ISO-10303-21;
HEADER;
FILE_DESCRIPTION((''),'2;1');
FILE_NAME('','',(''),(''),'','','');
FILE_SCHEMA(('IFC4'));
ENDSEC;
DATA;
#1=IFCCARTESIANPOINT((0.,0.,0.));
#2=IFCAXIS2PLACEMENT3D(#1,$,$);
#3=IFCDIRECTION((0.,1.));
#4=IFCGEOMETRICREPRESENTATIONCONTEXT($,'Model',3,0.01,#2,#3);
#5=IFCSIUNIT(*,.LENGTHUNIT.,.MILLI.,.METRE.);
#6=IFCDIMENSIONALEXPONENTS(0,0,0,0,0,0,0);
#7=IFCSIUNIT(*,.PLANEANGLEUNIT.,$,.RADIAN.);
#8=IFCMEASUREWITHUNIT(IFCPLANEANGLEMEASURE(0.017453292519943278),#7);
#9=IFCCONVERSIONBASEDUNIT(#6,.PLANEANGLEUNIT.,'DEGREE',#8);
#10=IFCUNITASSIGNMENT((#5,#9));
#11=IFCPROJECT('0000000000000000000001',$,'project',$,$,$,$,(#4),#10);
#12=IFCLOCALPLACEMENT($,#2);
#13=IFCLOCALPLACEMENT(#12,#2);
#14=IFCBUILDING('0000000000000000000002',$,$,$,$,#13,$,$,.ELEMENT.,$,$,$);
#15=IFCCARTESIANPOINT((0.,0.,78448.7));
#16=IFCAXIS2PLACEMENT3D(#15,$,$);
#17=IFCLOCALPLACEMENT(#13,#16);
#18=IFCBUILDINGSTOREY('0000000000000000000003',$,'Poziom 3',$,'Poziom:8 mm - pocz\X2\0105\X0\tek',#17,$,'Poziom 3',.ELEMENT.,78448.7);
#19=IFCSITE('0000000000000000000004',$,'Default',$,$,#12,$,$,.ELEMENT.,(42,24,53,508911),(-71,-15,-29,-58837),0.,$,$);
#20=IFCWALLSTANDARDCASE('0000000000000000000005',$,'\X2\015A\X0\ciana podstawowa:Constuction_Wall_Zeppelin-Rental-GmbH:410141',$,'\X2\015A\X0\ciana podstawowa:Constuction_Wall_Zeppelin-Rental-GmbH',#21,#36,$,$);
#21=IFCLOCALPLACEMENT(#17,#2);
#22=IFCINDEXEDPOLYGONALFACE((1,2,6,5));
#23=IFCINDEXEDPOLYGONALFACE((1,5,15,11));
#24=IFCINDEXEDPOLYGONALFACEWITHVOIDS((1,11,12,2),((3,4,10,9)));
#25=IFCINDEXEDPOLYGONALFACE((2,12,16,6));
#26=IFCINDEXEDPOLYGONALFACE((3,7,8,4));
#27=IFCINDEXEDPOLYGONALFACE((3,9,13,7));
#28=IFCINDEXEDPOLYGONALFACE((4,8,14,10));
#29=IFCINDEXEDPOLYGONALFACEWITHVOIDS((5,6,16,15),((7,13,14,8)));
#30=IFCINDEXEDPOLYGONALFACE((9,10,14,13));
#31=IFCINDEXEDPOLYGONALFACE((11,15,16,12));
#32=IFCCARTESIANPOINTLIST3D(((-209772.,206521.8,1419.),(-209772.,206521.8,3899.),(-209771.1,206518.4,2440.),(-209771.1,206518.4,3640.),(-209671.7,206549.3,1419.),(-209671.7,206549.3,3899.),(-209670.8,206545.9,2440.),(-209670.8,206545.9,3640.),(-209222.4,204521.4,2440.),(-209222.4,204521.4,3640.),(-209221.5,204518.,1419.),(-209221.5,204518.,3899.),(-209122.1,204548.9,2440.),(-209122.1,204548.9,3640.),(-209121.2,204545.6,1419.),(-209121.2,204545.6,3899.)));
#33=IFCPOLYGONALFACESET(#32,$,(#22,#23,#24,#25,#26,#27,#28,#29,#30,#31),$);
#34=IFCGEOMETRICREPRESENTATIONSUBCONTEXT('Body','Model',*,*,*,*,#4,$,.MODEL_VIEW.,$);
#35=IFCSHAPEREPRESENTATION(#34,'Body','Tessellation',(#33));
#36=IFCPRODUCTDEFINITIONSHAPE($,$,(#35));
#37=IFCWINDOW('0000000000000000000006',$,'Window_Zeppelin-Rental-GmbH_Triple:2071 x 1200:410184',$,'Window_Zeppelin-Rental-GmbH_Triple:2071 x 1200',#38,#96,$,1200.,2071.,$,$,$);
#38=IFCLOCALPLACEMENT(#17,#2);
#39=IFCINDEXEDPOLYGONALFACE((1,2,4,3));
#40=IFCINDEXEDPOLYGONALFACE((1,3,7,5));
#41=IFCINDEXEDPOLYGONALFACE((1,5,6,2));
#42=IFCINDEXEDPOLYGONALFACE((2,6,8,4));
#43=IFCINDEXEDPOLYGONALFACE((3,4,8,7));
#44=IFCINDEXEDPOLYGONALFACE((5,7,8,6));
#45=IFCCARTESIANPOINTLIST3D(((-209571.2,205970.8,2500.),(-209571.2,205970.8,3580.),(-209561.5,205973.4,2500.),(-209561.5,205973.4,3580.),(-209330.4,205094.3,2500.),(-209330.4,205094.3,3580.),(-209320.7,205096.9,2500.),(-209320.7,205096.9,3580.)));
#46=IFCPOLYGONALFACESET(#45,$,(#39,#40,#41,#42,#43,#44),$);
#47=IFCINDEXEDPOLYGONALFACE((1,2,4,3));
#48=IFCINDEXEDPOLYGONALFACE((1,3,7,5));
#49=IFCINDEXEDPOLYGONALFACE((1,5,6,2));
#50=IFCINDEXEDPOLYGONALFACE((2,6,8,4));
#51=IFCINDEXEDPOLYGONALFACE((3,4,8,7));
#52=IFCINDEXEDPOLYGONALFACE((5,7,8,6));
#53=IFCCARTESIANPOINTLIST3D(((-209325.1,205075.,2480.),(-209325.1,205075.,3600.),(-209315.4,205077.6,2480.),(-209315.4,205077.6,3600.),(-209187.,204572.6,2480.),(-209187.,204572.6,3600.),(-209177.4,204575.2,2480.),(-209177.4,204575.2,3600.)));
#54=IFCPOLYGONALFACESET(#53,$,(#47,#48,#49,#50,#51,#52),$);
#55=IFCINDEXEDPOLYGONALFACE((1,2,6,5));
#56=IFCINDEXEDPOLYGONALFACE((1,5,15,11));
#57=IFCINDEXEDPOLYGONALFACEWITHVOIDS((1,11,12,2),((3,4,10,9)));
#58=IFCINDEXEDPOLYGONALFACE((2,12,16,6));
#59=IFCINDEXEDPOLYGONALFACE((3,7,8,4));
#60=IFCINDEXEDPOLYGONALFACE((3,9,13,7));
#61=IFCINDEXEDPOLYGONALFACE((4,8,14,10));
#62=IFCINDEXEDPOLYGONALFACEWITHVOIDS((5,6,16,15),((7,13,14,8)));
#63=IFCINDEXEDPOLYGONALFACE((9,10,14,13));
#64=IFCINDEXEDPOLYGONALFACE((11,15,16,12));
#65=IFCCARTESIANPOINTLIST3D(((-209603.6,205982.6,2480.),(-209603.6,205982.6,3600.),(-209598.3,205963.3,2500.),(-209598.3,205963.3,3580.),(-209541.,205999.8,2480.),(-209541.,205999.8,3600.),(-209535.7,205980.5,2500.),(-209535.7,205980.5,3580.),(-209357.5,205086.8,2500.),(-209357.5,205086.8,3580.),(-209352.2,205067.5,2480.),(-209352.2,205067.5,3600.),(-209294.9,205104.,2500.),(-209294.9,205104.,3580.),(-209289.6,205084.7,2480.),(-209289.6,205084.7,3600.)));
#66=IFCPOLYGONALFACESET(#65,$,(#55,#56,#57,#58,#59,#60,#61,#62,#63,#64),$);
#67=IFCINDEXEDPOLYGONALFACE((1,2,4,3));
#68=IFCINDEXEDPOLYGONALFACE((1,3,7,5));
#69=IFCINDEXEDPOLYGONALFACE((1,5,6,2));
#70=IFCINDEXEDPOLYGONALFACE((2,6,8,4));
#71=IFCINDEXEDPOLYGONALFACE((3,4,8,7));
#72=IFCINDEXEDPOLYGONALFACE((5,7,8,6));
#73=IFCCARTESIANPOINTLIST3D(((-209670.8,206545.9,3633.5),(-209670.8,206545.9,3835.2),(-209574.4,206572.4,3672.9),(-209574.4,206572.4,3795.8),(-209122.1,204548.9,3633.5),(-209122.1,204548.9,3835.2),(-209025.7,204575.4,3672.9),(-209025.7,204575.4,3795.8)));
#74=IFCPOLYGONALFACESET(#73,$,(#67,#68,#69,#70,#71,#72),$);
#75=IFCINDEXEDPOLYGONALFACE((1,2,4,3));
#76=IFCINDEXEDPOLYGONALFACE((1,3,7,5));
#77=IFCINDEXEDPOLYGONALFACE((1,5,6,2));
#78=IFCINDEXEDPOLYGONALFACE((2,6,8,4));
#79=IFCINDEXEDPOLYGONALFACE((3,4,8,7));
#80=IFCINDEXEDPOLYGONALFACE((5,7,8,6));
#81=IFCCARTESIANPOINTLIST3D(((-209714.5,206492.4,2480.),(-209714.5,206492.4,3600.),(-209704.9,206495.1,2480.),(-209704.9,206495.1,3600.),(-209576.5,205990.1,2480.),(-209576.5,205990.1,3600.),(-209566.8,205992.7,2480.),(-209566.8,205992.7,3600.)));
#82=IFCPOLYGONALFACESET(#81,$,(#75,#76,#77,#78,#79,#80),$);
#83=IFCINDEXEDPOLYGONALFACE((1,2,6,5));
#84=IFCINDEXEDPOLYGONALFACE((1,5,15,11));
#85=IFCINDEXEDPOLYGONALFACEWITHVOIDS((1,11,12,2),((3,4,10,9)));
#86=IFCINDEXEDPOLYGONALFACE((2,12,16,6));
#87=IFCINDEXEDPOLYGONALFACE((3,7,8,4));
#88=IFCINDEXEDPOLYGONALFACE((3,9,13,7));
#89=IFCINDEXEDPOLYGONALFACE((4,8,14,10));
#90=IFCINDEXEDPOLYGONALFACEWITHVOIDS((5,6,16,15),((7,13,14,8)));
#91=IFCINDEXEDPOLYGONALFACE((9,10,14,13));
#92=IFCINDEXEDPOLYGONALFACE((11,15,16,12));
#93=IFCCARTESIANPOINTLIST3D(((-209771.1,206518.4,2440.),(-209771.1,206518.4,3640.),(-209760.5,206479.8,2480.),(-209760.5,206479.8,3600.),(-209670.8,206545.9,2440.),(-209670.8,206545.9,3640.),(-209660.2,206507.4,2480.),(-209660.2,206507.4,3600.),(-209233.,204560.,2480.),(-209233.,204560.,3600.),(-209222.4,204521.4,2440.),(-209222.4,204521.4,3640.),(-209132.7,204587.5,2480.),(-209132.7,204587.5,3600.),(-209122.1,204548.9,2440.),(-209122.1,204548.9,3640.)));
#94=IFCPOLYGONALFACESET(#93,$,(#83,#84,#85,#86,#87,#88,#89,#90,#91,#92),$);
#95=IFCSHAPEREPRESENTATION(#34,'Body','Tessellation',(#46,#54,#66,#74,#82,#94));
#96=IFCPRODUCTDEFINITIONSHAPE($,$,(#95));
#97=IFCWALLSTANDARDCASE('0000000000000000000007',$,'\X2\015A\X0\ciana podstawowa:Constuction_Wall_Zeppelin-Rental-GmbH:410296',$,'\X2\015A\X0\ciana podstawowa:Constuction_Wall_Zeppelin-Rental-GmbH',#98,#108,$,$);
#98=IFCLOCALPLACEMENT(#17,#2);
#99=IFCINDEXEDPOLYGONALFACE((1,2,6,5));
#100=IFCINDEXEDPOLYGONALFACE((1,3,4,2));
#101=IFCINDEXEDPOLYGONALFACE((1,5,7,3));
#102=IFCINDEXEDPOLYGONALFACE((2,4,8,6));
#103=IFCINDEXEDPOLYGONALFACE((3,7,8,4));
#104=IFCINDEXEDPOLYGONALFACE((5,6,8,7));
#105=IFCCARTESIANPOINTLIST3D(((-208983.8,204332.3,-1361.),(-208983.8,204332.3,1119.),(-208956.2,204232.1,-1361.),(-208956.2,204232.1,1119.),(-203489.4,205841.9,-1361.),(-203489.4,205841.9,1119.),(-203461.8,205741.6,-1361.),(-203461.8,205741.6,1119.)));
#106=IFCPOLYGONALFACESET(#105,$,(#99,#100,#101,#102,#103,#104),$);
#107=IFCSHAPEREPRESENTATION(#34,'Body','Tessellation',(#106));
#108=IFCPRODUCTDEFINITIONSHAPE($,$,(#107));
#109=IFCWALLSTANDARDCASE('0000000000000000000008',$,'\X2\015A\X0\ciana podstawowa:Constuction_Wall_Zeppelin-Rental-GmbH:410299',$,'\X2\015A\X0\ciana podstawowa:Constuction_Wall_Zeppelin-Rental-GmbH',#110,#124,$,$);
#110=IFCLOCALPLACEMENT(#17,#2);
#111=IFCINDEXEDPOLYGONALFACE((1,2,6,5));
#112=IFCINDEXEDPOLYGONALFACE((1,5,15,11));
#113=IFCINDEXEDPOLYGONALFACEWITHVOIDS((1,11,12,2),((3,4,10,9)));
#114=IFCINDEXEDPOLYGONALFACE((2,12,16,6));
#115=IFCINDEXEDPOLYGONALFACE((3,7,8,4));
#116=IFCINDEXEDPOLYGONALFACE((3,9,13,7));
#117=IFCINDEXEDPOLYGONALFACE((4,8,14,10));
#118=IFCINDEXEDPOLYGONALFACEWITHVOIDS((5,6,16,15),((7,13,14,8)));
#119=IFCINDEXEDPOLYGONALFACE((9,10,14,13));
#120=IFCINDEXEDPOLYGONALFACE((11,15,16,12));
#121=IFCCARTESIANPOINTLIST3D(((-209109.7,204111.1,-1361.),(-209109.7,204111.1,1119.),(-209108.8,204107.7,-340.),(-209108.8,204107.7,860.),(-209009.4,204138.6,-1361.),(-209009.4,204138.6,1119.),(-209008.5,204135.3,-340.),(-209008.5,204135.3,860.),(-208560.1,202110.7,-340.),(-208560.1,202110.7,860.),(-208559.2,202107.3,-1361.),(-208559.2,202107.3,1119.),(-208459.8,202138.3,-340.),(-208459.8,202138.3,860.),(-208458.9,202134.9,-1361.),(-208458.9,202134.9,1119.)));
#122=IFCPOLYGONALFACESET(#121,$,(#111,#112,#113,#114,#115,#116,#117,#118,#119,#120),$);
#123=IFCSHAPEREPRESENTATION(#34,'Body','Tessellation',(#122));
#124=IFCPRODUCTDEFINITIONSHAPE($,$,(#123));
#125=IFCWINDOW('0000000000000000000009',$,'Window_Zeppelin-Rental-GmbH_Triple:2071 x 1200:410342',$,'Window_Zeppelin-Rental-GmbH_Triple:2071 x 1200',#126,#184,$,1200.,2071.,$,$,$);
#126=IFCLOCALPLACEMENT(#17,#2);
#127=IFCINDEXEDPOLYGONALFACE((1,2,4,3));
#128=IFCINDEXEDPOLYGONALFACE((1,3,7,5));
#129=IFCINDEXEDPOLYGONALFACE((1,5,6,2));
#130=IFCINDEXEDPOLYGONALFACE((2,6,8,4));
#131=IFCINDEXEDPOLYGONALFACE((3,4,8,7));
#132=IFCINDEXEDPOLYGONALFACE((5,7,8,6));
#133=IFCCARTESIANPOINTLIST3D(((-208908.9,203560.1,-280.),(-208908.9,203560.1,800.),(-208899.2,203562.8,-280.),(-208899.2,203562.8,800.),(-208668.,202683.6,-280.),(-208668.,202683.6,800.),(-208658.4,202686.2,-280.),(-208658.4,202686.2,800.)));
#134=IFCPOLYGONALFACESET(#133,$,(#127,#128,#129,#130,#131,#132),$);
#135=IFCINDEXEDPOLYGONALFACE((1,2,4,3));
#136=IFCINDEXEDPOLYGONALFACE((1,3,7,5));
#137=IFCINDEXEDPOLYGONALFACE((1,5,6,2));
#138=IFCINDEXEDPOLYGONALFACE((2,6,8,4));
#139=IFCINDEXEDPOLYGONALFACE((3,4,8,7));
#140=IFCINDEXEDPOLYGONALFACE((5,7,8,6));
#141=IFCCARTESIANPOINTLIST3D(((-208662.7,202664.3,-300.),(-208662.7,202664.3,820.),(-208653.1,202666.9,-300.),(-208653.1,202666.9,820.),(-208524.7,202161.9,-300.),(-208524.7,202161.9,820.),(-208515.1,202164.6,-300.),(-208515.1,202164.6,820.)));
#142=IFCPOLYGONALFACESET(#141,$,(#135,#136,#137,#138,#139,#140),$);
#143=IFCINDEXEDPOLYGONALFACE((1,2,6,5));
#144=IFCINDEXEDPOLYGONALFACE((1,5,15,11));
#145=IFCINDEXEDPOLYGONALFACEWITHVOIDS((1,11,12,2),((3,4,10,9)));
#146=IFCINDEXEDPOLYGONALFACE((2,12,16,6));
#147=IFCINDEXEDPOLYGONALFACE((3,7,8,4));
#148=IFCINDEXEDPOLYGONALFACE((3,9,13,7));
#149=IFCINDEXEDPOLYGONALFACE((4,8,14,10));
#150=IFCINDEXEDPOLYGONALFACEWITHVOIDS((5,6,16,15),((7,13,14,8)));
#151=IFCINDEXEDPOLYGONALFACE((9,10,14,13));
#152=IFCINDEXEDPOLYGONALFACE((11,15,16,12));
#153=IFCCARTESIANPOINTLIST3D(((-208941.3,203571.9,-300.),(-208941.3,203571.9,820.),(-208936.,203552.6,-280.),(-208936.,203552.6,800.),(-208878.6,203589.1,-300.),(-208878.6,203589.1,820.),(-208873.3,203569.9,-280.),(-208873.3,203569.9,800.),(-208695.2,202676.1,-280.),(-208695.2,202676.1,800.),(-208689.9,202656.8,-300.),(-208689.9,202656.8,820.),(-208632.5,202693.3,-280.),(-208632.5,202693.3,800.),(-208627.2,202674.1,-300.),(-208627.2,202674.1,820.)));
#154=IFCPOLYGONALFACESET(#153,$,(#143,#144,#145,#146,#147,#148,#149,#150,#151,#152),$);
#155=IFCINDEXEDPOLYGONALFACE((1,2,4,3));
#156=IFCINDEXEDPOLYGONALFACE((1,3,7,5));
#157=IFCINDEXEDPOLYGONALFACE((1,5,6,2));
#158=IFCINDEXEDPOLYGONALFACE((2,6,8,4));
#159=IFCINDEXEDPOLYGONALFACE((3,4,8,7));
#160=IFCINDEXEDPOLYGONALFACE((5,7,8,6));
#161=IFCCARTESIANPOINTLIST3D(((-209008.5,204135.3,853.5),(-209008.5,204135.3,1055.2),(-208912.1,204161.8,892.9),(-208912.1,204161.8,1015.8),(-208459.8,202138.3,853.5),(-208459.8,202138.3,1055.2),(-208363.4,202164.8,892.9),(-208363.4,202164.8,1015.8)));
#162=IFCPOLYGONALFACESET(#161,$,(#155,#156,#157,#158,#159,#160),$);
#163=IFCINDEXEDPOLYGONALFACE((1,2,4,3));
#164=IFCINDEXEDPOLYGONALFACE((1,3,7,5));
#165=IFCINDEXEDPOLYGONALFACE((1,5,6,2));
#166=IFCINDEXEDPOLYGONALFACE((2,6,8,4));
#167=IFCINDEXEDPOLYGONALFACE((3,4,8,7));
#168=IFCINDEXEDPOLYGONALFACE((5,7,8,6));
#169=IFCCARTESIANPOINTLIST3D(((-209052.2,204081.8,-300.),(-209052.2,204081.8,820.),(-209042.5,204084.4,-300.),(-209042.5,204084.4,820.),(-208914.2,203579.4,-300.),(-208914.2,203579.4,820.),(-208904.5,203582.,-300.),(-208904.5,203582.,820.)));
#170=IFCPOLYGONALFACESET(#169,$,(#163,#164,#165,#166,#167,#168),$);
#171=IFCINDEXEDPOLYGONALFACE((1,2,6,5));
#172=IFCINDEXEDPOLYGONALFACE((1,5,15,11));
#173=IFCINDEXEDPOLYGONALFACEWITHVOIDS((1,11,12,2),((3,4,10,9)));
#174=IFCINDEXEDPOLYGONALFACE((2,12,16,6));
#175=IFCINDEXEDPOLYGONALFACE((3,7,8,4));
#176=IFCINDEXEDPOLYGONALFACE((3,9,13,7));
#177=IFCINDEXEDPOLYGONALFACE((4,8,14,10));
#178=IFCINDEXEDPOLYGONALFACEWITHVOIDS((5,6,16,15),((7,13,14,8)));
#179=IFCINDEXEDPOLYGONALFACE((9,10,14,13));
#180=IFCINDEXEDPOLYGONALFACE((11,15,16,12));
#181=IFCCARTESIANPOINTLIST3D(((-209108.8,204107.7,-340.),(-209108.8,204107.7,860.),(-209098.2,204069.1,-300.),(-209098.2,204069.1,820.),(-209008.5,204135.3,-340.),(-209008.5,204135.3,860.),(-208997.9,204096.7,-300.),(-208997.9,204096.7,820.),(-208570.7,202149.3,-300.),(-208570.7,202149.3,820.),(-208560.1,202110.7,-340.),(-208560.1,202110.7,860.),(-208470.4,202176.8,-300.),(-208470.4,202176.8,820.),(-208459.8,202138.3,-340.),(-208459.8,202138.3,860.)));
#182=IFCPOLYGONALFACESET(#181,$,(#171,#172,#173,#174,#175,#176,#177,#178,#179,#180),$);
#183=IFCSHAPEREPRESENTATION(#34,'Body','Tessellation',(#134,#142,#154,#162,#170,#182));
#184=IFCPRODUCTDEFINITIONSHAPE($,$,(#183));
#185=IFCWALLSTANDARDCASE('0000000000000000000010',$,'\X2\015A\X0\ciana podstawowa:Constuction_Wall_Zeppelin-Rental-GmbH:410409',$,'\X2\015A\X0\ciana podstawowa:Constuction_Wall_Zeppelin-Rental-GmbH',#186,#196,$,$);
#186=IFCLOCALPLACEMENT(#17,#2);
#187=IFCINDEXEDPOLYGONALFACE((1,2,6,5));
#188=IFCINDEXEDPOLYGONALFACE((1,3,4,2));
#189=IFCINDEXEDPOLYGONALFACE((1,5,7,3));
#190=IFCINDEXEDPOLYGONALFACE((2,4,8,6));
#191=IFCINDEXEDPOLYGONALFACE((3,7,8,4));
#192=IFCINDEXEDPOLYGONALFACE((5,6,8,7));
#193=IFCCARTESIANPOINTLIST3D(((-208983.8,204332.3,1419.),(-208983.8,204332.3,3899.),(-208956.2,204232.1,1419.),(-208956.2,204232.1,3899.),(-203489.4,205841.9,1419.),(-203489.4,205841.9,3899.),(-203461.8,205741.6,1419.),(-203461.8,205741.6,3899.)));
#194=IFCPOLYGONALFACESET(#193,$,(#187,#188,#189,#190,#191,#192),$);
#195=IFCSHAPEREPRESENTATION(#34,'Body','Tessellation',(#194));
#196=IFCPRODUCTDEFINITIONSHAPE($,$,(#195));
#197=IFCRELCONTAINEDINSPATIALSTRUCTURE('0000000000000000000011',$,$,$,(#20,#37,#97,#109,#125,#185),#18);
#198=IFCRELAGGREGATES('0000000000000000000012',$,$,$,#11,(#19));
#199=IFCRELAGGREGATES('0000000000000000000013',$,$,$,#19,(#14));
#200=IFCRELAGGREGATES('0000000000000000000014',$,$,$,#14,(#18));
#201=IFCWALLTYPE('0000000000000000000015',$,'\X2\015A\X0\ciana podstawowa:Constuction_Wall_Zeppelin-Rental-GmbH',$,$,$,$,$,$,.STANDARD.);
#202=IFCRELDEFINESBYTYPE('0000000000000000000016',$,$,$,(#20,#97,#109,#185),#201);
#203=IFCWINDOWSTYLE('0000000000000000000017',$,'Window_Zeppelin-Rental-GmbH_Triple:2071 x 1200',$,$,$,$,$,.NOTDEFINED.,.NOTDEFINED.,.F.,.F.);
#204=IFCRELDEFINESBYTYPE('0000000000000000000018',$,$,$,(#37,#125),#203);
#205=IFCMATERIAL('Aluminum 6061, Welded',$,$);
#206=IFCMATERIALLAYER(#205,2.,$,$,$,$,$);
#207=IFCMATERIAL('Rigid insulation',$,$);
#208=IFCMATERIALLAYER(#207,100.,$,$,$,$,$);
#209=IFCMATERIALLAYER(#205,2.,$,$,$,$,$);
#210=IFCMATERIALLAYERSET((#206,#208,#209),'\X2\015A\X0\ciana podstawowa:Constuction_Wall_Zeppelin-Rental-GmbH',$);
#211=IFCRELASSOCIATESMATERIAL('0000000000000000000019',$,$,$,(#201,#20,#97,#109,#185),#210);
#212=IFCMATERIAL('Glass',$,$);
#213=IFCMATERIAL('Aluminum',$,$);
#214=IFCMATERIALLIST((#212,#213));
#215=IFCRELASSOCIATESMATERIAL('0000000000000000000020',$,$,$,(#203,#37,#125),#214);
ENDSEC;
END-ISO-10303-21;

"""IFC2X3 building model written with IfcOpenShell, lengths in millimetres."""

from ifc_helpers import new_model, entity, si_unit, converted_unit, direction, frame, frame_2d, origin, origin_2d_with_axis, place, context, subcontext, project, spatial, polyline, rectangle, outline, extrude, source, transform, mapped, material, material_list, layer, layer_set, layer_usage, type_object, type_shapes, element, fill, save


model = new_model("IFC2X3")

# Units and contexts
model_context = context("Model", 3, precision=0.01, world=origin(), true_north=direction((0.0, 1.0)))
body_context = subcontext(model_context, "Body", "Model", "MODEL_VIEW")
ifc_project = project(units=[si_unit("LENGTHUNIT", "METRE", prefix="MILLI"), converted_unit("PLANEANGLEUNIT", "DEGREE", entity("IfcPlaneAngleMeasure", 0.017453292519943278), si_unit("PLANEANGLEUNIT", "RADIAN"), dimensions=[0, 0, 0, 0, 0, 0, 0])], contexts=[model_context])

# Site, building, storey
site_placement = place(None, origin())
site = spatial("IfcSite", under=ifc_project, at=site_placement, Name="Default", CompositionType="ELEMENT", RefLatitude=(42, 24, 53, 508911), RefLongitude=(-71, -15, -29, -58837), RefElevation=0.0)
building_placement = place(site_placement, origin())
building = spatial("IfcBuilding", under=site, at=building_placement, CompositionType="ELEMENT")
storey_placement = place(building_placement, frame((0.0, 0.0, 78448.7)))
storey = spatial("IfcBuildingStorey", under=building, at=storey_placement, Name="Poziom 3", ObjectType="Poziom:8 mm - początek", LongName="Poziom 3", CompositionType="ELEMENT", Elevation=78448.7)

# Shared definitions
ifc_material_1 = material(Name="Aluminum 6061, Welded")
ifc_layer_1 = layer(ifc_material_1, 2.0)
ifc_material_2 = material(Name="Rigid insulation")
ifc_layer_2 = layer(ifc_material_2, 100.0)
ifc_layer_3 = layer(ifc_material_1, 2.0)
ifc_layer_set_1 = layer_set([ifc_layer_1, ifc_layer_2, ifc_layer_3], Name="Ściana podstawowa:Constuction_Wall_Zeppelin-Rental-GmbH")
wall_type_1 = type_object("IfcWallType", Name="Ściana podstawowa:Constuction_Wall_Zeppelin-Rental-GmbH", PredefinedType="STANDARD", material=ifc_layer_set_1)

# Shared definitions
ifc_material_3 = material(Name="Glass")
ifc_material_4 = material(Name="Aluminum")
ifc_material_list = material_list([ifc_material_3, ifc_material_4])
window_style = type_object("IfcWindowStyle", Name="Window_Zeppelin-Rental-GmbH_Triple:2071 x 1200", ConstructionType="NOTDEFINED", OperationType="NOTDEFINED", ParameterTakesPrecedence=False, Sizeable=False, material=ifc_material_list)
shared_shape_1 = source(origin(), body_context, "Body", "SweptSolid", [
    extrude(rectangle(XDim=10.0, YDim=909.0, at=origin_2d_with_axis()), frame((1035.5, 52.7, 60.0), z_axis=(0.0, 0.0, 1.0), x_axis=(0.0, -1.0, 0.0)), (0.0, 0.0, 1.0), 1080.0),
    extrude(rectangle(XDim=521.0, YDim=10.0, at=frame_2d((0.0, 0.0), x_axis=(1.0, 0.0))), frame((300.5, 52.7, 40.0), z_axis=(0.0, 0.0, 1.0), x_axis=(-1.0, 0.0, 0.0)), (0.0, 0.0, 1.0), 1120.0),
    extrude(outline(polyline([(-474.5, -560.0), (474.5, -560.0), (474.5, 560.0), (-474.5, 560.0), (-474.5, -560.0)]), holes=[polyline([(-454.5, 540.0), (454.5, 540.0), (454.5, -540.0), (-454.5, -540.0), (-454.5, 540.0)])]), frame((1035.5, 85.8, 600.0), z_axis=(0.0, -1.0, 0.0), x_axis=(1.0, 0.0, 0.0)), (0.0, 0.0, 1.0), 65.0),
    extrude(outline(polyline([(-24.0, -75.5), (83.5, -75.5), (9.6, 112.1), (-69.0, 38.9), (-24.0, -75.5)])), frame((2071.0, -48.7, 1294.4), z_axis=(-1.0, 0.0, 0.0), x_axis=(0.0, 0.930458, 0.366398)), (0.0, 0.0, 1.0), 2071.0),
    extrude(rectangle(XDim=10.0, YDim=521.0, at=frame_2d((0.0, 0.0), x_axis=(1.0, 0.0))), frame((1770.5, 52.7, 40.0), z_axis=(0.0, 0.0, 1.0), x_axis=(0.0, -1.0, 0.0)), (0.0, 0.0, 1.0), 1120.0),
    extrude(outline(polyline([(-1035.5, -600.0), (1035.5, -600.0), (1035.5, 600.0), (-1035.5, 600.0), (-1035.5, -600.0)]), holes=[polyline([(-995.5, 560.0), (995.5, 560.0), (995.5, -560.0), (-995.5, -560.0), (-995.5, 560.0)])]), frame((1035.5, 105.3, 600.0), z_axis=(0.0, -1.0, 0.0), x_axis=(1.0, 0.0, 0.0)), (0.0, 0.0, 1.0), 104.0),
])
type_shapes(window_style, [shared_shape_1])

# Wall, opening, window
ifc_layer_usage_1 = layer_usage(ifc_layer_set_1, "AXIS2", "NEGATIVE", 52.0)
wall_1_placement = place(storey_placement, frame((-209171.3, 204531.8, 1419.0), z_axis=(0.0, 0.0, 1.0), x_axis=(-0.264931, 0.964267, 0.0)))
wall_1 = element("IfcWallStandardCase", 1, at=wall_1_placement, inside=storey, type_object=wall_type_1, material=ifc_layer_usage_1, Name="Ściana podstawowa:Constuction_Wall_Zeppelin-Rental-GmbH:410141", ObjectType="Ściana podstawowa:Constuction_Wall_Zeppelin-Rental-GmbH", context=body_context, shape_type="SweptSolid", body=[
    extrude(rectangle(XDim=2078.0, YDim=104.0, at=frame_2d((1039.0, 0.0), x_axis=(-1.0, 0.0))), origin(), (0.0, 0.0, 1.0), 2480.0),
])
opening_1_placement = place(wall_1_placement, frame((3.5, -52.0, 1021.0)))
opening_1 = element("IfcOpeningElement", 2, at=opening_1_placement, cuts=wall_1, ObjectType="Opening", context=body_context, shape_type="SweptSolid", body=[
    extrude(rectangle(XDim=1200.0, YDim=2071.0, at=frame_2d((600.0, 1035.5), x_axis=(1.0, 0.0))), frame((0.0, 0.0, 0.0), z_axis=(0.0, 1.0, 0.0), x_axis=(0.0, 0.0, 1.0)), (0.0, 0.0, 1.0), 104.0),
])
window_1_placement = place(opening_1_placement, frame((0.0, -1.3, 0.0)))
window_1 = element("IfcWindow", 3, at=window_1_placement, inside=storey, type_object=window_style, material=ifc_material_list, Name="Window_Zeppelin-Rental-GmbH_Triple:2071 x 1200:410184", ObjectType="Window_Zeppelin-Rental-GmbH_Triple:2071 x 1200", OverallHeight=1200.0, OverallWidth=2071.0, context=body_context, shape_type="MappedRepresentation", body=[
    mapped(shared_shape_1, transform((0.0, 0.0, 0.0), scale=1.0)),
])
fill(opening_1, window_1)

# Wall
ifc_layer_usage_2 = layer_usage(ifc_layer_set_1, "AXIS2", "NEGATIVE", 52.0)
wall_2_placement = place(storey_placement, frame((-208970.0, 204282.2, -1361.0), z_axis=(0.0, 0.0, 1.0), x_axis=(0.964267, 0.264931, 0.0)))
element("IfcWallStandardCase", 4, at=wall_2_placement, inside=storey, type_object=wall_type_1, material=ifc_layer_usage_2, Name="Ściana podstawowa:Constuction_Wall_Zeppelin-Rental-GmbH:410296", ObjectType="Ściana podstawowa:Constuction_Wall_Zeppelin-Rental-GmbH", context=body_context, shape_type="SweptSolid", body=[
    extrude(rectangle(XDim=5698.0, YDim=104.0, at=frame_2d((2849.0, 0.0), x_axis=(-1.0, 0.0))), origin(), (0.0, 0.0, 1.0), 2480.0),
])

# Wall, opening, window
ifc_layer_usage_3 = layer_usage(ifc_layer_set_1, "AXIS2", "NEGATIVE", 52.0)
wall_3_placement = place(storey_placement, frame((-208509.0, 202121.1, -1361.0), z_axis=(0.0, 0.0, 1.0), x_axis=(-0.264931, 0.964267, 0.0)))
wall_3 = element("IfcWallStandardCase", 5, at=wall_3_placement, inside=storey, type_object=wall_type_1, material=ifc_layer_usage_3, Name="Ściana podstawowa:Constuction_Wall_Zeppelin-Rental-GmbH:410299", ObjectType="Ściana podstawowa:Constuction_Wall_Zeppelin-Rental-GmbH", context=body_context, shape_type="SweptSolid", body=[
    extrude(rectangle(XDim=2078.0, YDim=104.0, at=frame_2d((1039.0, 0.0), x_axis=(-1.0, 0.0))), origin(), (0.0, 0.0, 1.0), 2480.0),
])
opening_2_placement = place(wall_3_placement, frame((3.5, -52.0, 1021.0)))
opening_2 = element("IfcOpeningElement", 6, at=opening_2_placement, cuts=wall_3, ObjectType="Opening", context=body_context, shape_type="SweptSolid", body=[
    extrude(rectangle(XDim=1200.0, YDim=2071.0, at=frame_2d((600.0, 1035.5), x_axis=(1.0, 0.0))), frame((0.0, 0.0, 0.0), z_axis=(0.0, 1.0, 0.0), x_axis=(0.0, 0.0, 1.0)), (0.0, 0.0, 1.0), 104.0),
])
window_2_placement = place(opening_2_placement, frame((0.0, -1.3, 0.0)))
window_2 = element("IfcWindow", 7, at=window_2_placement, inside=storey, type_object=window_style, material=ifc_material_list, Name="Window_Zeppelin-Rental-GmbH_Triple:2071 x 1200:410342", ObjectType="Window_Zeppelin-Rental-GmbH_Triple:2071 x 1200", OverallHeight=1200.0, OverallWidth=2071.0, context=body_context, shape_type="MappedRepresentation", body=[
    mapped(shared_shape_1, transform((0.0, 0.0, 0.0), scale=1.0)),
])
fill(opening_2, window_2)

# Wall
ifc_layer_usage_4 = layer_usage(ifc_layer_set_1, "AXIS2", "NEGATIVE", 52.0)
wall_4_placement = place(storey_placement, frame((-208970.0, 204282.2, 1419.0), z_axis=(0.0, 0.0, 1.0), x_axis=(0.964267, 0.264931, 0.0)))
element("IfcWallStandardCase", 8, at=wall_4_placement, inside=storey, type_object=wall_type_1, material=ifc_layer_usage_4, Name="Ściana podstawowa:Constuction_Wall_Zeppelin-Rental-GmbH:410409", ObjectType="Ściana podstawowa:Constuction_Wall_Zeppelin-Rental-GmbH", context=body_context, shape_type="SweptSolid", body=[
    extrude(rectangle(XDim=5698.0, YDim=104.0, at=frame_2d((2849.0, 0.0), x_axis=(-1.0, 0.0))), origin(), (0.0, 0.0, 1.0), 2480.0),
])

save(model, "model.ifc")
